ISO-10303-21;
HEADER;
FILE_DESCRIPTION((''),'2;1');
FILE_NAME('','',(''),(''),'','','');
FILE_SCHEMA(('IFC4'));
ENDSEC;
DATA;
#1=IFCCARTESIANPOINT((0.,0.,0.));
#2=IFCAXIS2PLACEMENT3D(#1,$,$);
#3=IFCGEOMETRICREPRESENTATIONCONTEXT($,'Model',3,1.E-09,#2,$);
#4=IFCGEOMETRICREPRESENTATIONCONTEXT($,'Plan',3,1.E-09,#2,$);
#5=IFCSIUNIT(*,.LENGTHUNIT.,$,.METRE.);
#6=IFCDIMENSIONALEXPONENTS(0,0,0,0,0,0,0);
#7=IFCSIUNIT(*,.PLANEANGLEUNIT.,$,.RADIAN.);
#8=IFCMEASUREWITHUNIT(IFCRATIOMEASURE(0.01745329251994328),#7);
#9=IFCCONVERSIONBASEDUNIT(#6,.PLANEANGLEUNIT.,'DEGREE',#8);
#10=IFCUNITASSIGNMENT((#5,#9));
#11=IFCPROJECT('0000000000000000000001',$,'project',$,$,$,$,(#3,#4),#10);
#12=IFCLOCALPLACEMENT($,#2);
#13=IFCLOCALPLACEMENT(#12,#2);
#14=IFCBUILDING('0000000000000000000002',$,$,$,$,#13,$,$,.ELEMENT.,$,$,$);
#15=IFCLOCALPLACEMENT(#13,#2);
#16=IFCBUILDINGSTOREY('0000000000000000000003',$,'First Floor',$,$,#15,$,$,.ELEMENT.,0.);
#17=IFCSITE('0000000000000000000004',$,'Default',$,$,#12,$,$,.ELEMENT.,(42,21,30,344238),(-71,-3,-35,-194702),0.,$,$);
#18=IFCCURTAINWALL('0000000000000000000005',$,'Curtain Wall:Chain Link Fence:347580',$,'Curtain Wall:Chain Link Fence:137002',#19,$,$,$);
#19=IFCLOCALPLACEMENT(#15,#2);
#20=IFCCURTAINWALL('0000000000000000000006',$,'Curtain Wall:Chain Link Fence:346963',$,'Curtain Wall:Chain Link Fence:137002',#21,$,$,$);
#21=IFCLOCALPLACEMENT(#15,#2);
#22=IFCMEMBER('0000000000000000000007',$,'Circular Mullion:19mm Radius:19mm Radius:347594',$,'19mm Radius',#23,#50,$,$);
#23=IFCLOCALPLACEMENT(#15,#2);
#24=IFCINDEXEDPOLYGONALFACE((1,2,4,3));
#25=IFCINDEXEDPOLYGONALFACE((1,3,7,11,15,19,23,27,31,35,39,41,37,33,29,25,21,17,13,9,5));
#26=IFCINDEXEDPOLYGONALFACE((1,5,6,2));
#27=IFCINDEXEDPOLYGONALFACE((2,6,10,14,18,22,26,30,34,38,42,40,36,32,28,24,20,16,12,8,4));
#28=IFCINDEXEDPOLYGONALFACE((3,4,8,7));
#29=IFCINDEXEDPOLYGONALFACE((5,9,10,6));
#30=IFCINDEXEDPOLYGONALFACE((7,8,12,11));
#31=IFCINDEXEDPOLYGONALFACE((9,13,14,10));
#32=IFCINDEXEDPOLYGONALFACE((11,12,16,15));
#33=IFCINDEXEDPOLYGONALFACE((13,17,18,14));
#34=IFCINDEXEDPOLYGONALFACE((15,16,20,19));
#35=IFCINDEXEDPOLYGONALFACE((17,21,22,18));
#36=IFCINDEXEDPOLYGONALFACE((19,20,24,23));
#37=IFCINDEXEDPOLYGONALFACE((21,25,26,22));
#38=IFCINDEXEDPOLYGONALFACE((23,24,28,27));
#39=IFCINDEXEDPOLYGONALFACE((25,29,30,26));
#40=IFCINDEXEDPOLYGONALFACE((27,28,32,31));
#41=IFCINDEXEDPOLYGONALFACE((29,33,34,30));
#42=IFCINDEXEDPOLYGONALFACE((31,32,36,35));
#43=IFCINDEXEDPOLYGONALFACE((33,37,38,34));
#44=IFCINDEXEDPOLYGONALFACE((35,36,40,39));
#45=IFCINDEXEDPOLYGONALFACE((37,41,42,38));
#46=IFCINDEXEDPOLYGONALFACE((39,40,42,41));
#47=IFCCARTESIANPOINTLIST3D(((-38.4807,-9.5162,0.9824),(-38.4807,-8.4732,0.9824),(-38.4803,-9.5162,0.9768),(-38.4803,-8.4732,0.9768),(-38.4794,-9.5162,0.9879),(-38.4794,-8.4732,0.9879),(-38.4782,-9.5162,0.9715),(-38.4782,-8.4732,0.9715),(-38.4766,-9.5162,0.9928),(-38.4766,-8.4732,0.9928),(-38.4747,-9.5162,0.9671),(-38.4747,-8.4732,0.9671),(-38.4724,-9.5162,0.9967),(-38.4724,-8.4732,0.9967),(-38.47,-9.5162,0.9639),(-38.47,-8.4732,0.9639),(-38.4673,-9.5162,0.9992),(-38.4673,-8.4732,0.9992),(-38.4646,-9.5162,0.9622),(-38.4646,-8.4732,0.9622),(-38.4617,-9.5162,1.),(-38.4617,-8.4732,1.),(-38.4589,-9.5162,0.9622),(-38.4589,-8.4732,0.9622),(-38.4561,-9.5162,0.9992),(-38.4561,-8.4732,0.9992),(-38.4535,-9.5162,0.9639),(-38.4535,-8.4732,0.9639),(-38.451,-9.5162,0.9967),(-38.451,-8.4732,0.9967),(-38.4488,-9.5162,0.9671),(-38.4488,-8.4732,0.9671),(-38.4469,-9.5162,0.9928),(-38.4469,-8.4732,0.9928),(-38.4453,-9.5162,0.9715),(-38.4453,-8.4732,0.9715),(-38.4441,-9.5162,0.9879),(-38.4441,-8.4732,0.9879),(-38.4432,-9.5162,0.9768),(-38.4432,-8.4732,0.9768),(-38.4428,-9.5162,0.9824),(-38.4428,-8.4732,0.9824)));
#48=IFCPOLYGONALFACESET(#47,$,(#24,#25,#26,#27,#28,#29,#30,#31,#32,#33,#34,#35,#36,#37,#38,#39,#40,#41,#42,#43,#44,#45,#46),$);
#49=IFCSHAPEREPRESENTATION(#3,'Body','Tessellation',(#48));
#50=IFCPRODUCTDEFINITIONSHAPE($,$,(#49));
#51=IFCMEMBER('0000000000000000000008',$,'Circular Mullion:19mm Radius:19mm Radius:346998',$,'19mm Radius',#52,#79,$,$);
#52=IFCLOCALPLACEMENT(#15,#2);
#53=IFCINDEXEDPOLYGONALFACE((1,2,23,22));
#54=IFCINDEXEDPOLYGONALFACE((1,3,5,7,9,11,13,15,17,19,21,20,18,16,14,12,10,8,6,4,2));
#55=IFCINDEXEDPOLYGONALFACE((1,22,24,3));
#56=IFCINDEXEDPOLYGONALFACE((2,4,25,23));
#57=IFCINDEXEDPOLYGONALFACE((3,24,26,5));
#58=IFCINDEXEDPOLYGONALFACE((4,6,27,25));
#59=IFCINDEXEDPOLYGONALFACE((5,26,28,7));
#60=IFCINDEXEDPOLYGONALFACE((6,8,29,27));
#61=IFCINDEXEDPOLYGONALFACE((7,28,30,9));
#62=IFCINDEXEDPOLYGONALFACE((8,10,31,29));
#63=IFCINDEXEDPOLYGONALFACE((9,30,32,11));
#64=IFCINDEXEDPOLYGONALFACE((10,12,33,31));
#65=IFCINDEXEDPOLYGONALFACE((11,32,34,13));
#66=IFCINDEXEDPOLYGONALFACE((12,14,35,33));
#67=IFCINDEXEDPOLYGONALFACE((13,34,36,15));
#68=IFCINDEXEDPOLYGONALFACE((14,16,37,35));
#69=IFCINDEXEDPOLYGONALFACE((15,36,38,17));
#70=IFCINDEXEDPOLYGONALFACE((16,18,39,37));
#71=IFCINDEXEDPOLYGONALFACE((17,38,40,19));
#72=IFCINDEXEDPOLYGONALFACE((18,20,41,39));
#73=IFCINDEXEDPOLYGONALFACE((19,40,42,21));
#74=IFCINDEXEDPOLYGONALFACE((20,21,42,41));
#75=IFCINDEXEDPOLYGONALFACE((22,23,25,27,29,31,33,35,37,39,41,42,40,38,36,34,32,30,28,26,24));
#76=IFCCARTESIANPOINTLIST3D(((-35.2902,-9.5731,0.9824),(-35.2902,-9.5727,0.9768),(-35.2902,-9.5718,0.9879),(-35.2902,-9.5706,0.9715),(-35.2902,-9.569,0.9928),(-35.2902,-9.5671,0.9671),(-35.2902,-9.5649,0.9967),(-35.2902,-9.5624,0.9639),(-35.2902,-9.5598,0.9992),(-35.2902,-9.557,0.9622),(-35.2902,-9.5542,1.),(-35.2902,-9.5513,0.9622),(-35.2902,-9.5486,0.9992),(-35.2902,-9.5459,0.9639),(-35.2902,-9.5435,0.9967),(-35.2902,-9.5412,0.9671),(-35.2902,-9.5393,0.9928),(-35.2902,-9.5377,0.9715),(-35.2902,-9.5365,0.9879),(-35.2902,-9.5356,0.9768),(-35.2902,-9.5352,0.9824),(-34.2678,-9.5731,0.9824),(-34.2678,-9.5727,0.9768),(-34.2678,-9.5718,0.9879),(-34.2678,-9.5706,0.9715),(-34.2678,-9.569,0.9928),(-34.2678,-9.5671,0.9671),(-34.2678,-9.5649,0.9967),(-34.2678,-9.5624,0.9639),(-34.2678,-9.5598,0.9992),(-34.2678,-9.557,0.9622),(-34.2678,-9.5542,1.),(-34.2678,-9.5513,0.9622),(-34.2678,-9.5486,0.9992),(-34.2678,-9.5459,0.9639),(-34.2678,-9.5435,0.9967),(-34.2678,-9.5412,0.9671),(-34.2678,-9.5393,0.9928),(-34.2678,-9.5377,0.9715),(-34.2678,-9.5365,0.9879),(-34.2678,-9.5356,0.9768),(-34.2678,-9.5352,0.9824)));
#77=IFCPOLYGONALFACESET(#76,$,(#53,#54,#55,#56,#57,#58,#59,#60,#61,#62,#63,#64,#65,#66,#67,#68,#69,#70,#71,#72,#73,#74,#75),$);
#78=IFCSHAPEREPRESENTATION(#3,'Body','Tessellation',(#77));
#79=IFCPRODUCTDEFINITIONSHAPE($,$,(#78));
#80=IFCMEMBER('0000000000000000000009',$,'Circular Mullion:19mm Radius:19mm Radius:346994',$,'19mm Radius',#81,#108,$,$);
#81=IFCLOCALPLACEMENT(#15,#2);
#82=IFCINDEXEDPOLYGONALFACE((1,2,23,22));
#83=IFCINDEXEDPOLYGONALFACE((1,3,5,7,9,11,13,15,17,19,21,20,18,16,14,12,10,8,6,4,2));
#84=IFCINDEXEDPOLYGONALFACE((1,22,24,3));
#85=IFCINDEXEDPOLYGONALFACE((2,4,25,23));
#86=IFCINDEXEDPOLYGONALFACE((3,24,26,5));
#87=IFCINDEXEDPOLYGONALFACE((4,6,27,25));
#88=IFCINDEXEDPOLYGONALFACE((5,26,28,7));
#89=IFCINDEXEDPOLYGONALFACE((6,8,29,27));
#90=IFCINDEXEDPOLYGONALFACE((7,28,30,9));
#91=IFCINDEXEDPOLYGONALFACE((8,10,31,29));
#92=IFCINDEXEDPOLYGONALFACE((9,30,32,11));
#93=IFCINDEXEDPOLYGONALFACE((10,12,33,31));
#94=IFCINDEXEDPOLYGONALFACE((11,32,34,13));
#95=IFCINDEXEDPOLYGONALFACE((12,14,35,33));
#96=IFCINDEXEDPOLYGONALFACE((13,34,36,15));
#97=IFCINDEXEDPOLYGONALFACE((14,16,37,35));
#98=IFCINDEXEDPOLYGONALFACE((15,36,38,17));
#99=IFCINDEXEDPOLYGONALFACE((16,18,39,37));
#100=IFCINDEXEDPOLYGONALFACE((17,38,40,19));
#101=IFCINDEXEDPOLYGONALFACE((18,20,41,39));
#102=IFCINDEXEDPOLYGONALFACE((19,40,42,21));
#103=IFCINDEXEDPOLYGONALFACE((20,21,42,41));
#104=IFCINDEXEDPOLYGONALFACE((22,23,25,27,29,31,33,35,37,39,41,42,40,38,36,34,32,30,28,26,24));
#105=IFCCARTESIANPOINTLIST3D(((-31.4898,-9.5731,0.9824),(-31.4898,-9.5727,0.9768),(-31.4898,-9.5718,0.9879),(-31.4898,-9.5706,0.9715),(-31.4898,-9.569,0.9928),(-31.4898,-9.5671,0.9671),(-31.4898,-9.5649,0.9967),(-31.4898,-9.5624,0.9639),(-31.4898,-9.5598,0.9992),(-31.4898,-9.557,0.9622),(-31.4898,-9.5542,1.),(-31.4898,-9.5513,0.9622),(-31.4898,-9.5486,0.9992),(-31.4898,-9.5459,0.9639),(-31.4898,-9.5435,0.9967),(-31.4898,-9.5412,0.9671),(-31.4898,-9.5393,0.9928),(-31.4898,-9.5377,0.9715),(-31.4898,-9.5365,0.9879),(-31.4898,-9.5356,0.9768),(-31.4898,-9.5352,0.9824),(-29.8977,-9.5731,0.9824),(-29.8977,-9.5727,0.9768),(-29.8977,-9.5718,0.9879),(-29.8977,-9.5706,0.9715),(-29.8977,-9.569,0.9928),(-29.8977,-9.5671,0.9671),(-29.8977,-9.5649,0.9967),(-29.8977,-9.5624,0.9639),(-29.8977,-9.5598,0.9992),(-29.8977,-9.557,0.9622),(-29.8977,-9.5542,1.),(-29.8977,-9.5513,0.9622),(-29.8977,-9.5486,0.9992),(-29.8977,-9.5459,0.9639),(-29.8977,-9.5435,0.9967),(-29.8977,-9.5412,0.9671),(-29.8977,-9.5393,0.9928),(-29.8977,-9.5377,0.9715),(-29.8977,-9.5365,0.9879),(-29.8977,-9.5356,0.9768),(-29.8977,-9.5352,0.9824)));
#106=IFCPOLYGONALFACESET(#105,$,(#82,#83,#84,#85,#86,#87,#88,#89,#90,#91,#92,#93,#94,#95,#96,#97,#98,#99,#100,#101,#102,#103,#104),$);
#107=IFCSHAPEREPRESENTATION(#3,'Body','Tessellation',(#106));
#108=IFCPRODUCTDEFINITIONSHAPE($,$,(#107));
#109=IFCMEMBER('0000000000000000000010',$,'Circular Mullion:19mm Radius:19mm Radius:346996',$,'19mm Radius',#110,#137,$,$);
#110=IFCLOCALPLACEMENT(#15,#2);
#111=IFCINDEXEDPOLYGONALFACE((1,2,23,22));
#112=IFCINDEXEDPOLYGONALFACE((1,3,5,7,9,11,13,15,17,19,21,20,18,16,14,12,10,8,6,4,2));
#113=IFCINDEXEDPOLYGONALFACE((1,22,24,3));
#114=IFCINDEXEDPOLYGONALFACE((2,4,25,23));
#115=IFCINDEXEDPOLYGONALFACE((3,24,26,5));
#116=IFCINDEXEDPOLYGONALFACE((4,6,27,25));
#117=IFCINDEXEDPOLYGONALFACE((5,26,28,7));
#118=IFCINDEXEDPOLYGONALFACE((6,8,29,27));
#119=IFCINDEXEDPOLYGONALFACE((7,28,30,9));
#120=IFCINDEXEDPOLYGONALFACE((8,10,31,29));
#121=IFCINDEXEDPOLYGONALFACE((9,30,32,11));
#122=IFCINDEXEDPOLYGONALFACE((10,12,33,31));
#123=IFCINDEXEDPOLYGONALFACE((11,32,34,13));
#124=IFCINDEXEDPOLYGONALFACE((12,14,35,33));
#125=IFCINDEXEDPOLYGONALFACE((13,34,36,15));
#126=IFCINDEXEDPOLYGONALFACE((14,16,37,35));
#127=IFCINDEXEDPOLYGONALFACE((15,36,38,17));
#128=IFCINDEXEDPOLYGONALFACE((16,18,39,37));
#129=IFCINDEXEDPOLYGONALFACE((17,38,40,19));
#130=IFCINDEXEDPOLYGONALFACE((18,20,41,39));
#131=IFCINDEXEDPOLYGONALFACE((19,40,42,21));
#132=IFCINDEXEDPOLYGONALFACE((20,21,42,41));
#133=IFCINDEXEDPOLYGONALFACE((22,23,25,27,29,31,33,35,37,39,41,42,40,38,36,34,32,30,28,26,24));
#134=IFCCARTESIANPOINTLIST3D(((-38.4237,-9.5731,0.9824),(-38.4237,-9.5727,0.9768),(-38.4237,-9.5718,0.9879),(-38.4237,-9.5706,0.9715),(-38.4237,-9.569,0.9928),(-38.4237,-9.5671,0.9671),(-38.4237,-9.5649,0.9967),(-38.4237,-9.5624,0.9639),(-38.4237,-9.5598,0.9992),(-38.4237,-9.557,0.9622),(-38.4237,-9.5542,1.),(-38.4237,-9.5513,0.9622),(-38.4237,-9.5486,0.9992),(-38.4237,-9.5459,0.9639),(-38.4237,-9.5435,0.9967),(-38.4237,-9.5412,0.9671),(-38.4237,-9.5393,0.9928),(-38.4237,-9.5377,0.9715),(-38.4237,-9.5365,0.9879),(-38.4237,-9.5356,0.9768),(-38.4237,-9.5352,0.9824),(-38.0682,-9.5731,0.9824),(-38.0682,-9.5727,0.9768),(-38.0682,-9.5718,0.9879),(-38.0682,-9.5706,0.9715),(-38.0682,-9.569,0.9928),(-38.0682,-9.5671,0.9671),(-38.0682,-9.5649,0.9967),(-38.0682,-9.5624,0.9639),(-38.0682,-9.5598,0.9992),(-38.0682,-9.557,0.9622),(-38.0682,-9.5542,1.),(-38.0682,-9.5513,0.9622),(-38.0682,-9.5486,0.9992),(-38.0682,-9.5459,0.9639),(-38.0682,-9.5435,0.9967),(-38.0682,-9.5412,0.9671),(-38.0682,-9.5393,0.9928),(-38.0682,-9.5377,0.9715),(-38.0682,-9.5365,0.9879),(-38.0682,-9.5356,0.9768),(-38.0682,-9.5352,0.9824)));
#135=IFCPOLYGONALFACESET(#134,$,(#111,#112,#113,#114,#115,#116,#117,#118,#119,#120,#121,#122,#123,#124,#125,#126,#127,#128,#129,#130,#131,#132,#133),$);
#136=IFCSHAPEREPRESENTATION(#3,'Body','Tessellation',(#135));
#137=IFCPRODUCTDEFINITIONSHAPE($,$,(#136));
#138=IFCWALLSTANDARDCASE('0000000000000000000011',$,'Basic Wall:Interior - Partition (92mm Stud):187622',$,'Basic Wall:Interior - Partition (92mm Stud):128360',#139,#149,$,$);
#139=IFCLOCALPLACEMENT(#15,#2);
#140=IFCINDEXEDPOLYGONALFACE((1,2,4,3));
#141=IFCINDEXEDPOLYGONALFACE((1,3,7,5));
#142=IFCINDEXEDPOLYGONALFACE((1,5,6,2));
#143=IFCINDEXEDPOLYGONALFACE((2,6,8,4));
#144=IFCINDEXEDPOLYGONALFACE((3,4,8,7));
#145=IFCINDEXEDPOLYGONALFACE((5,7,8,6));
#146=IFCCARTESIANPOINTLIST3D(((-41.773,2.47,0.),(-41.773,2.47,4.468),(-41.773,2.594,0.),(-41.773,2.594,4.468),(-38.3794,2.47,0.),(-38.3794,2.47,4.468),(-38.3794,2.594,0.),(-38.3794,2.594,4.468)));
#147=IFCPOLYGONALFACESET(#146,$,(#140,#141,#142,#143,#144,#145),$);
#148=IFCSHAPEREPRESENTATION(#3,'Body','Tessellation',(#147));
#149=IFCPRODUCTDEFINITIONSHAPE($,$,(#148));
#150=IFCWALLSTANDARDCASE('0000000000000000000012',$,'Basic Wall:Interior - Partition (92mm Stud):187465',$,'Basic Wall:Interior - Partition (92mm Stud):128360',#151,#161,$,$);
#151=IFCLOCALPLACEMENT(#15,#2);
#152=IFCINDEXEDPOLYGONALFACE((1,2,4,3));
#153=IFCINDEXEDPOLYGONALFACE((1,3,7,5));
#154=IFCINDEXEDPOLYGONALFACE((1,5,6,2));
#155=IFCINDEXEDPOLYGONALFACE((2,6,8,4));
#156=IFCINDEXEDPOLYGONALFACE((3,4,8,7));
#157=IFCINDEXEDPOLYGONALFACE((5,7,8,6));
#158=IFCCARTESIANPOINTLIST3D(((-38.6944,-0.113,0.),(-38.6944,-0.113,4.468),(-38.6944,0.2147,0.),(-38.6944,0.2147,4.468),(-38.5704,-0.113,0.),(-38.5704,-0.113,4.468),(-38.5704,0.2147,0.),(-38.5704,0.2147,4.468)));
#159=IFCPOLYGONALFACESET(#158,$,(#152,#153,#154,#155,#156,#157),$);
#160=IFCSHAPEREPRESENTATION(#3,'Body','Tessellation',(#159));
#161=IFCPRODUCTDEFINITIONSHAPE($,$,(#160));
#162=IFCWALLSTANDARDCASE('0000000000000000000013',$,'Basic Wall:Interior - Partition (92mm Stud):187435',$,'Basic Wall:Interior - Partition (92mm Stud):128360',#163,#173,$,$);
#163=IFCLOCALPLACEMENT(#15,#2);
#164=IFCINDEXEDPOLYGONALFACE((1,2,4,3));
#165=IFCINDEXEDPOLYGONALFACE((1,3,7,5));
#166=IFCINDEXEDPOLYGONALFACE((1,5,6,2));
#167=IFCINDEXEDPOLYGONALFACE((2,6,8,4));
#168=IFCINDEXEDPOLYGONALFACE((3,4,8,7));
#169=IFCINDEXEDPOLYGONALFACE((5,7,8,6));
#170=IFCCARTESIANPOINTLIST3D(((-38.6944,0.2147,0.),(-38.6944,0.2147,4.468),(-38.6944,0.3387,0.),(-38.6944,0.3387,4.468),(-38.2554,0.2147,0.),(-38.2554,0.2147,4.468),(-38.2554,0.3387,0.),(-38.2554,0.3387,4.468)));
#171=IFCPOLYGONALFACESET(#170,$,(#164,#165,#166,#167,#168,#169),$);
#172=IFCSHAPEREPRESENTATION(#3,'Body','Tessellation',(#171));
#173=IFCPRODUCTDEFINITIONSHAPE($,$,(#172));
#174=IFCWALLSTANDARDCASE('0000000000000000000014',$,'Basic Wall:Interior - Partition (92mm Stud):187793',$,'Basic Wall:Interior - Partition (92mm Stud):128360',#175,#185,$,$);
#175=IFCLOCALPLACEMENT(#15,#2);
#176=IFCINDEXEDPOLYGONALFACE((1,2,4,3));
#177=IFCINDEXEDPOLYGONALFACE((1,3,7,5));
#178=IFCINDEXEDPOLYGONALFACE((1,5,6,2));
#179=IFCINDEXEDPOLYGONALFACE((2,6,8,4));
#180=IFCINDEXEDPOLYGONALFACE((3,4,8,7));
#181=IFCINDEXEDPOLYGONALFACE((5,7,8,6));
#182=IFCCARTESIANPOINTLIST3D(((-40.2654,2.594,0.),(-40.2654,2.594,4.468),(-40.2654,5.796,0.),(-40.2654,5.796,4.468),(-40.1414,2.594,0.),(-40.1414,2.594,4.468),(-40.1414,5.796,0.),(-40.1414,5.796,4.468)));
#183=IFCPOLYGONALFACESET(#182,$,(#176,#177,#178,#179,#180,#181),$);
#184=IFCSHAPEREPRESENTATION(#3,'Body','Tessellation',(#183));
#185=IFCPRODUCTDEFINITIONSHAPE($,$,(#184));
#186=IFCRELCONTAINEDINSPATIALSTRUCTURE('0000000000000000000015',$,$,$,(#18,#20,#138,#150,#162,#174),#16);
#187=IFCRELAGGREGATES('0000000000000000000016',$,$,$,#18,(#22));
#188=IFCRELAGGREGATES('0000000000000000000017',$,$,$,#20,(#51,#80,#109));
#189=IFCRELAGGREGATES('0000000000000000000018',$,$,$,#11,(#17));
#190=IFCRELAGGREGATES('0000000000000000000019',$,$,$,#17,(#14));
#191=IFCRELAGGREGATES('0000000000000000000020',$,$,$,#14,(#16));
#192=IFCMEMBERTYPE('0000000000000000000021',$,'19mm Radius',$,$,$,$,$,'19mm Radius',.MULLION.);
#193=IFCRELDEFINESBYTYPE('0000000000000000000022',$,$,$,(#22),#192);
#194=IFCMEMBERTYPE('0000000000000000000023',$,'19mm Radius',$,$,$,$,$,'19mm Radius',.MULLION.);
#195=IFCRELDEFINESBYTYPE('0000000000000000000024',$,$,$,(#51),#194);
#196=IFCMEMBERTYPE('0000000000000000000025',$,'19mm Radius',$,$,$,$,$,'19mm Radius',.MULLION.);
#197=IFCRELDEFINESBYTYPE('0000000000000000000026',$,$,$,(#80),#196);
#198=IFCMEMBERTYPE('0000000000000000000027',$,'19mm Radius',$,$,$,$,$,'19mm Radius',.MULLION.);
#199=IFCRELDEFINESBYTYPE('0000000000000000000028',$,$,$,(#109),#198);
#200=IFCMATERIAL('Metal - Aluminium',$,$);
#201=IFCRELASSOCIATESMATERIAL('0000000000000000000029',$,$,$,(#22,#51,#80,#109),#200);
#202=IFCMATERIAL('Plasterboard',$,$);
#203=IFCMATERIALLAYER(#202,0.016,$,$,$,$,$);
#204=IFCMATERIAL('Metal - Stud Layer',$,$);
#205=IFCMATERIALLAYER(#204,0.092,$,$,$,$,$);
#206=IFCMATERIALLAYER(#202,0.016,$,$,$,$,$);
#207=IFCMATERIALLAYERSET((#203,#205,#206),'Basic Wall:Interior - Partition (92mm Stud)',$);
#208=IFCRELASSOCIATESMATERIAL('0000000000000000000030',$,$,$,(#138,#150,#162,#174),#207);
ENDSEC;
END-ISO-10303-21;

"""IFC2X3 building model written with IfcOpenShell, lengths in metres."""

from ifc_helpers import new_model, entity, si_unit, converted_unit, frame, frame_2d, origin, origin_2d_with_axis, place, context, project, spatial, rectangle, circle, extrude, source, transform, mapped, material, layer, layer_set, layer_usage, type_object, type_shapes, element, aggregate, save


model = new_model("IFC2X3")

# Units and contexts
model_context = context("Model", 3, precision=1e-09, world=origin())
plan_context = context("Plan", 3, precision=1e-09, world=origin())
ifc_project = project(units=[si_unit("LENGTHUNIT", "METRE"), converted_unit("PLANEANGLEUNIT", "DEGREE", entity("IfcRatioMeasure", 0.01745329251994328), si_unit("PLANEANGLEUNIT", "RADIAN"), dimensions=[0, 0, 0, 0, 0, 0, 0])], contexts=[model_context, plan_context])

# Site, building, storey
site_placement = place(None, origin())
site = spatial("IfcSite", under=ifc_project, at=site_placement, Name="Default", CompositionType="ELEMENT", RefLatitude=(42, 21, 30, 344238), RefLongitude=(-71, -3, -35, -194702), RefElevation=0.0)
building_placement = place(site_placement, origin())
building = spatial("IfcBuilding", under=site, at=building_placement, CompositionType="ELEMENT")
storey_placement = place(building_placement, origin())
storey = spatial("IfcBuildingStorey", under=building, at=storey_placement, Name="First Floor", CompositionType="ELEMENT", Elevation=0.0)

# Curtain walls
curtain_wall_1_placement = place(storey_placement, origin())
curtain_wall_1 = element("IfcCurtainWall", 1, at=curtain_wall_1_placement, inside=storey, Name="Curtain Wall:Chain Link Fence:347580", ObjectType="Curtain Wall:Chain Link Fence:137002")
ifc_material_1 = material(Name="Metal - Aluminium")
curtain_wall_2_placement = place(storey_placement, origin())
curtain_wall_2 = element("IfcCurtainWall", 2, at=curtain_wall_2_placement, inside=storey, Name="Curtain Wall:Chain Link Fence:346963", ObjectType="Curtain Wall:Chain Link Fence:137002")

# Members
member_type_1 = type_object("IfcMemberType", Name="19mm Radius", ElementType="19mm Radius", PredefinedType="MULLION")
shared_shape_1 = source(origin(), model_context, "Body", "SweptSolid", [
    extrude(circle(Radius=0.019, at=origin_2d_with_axis()), frame((-0.019, 0.0, -1.043)), (0.0, 0.0, 1.0), 1.043),
])
type_shapes(member_type_1, [shared_shape_1])
member_1_placement = place(storey_placement, frame((-38.4617, -8.4732, 1.0), z_axis=(0.0, 1.0, 0.0), x_axis=(0.0, 0.0, 1.0)))
member_1 = element("IfcMember", 3, at=member_1_placement, type_object=member_type_1, material=ifc_material_1, Name="Circular Mullion:19mm Radius:19mm Radius:347594", ObjectType="19mm Radius", context=model_context, shape_type="MappedRepresentation", body=[
    mapped(shared_shape_1, transform((0.0, 0.0, 0.0), scale=1.0)),
])
member_type_2 = type_object("IfcMemberType", Name="19mm Radius", ElementType="19mm Radius", PredefinedType="MULLION")
shared_shape_2 = source(origin(), model_context, "Body", "SweptSolid", [
    extrude(circle(Radius=0.019, at=origin_2d_with_axis()), frame((-0.019, 0.0, -1.0224)), (0.0, 0.0, 1.0), 1.0224),
])
type_shapes(member_type_2, [shared_shape_2])
member_2_placement = place(storey_placement, frame((-34.2678, -9.5542, 1.0), z_axis=(1.0, 0.0, 0.0), x_axis=(0.0, 0.0, 1.0)))
member_2 = element("IfcMember", 4, at=member_2_placement, type_object=member_type_2, material=ifc_material_1, Name="Circular Mullion:19mm Radius:19mm Radius:346998", ObjectType="19mm Radius", context=model_context, shape_type="MappedRepresentation", body=[
    mapped(shared_shape_2, transform((0.0, 0.0, 0.0), scale=1.0)),
])
member_type_3 = type_object("IfcMemberType", Name="19mm Radius", ElementType="19mm Radius", PredefinedType="MULLION")
shared_shape_3 = source(origin(), model_context, "Body", "SweptSolid", [
    extrude(circle(Radius=0.019, at=origin_2d_with_axis()), frame((-0.019, 0.0, -1.5921)), (0.0, 0.0, 1.0), 1.5921),
])
type_shapes(member_type_3, [shared_shape_3])
member_3_placement = place(storey_placement, frame((-29.8977, -9.5542, 1.0), z_axis=(1.0, 0.0, 0.0), x_axis=(0.0, 0.0, 1.0)))
member_3 = element("IfcMember", 5, at=member_3_placement, type_object=member_type_3, material=ifc_material_1, Name="Circular Mullion:19mm Radius:19mm Radius:346994", ObjectType="19mm Radius", context=model_context, shape_type="MappedRepresentation", body=[
    mapped(shared_shape_3, transform((0.0, 0.0, 0.0), scale=1.0)),
])
member_type_4 = type_object("IfcMemberType", Name="19mm Radius", ElementType="19mm Radius", PredefinedType="MULLION")
shared_shape_4 = source(origin(), model_context, "Body", "SweptSolid", [
    extrude(circle(Radius=0.019, at=origin_2d_with_axis()), frame((-0.019, 0.0, -0.3556)), (0.0, 0.0, 1.0), 0.3556),
])
type_shapes(member_type_4, [shared_shape_4])
member_4_placement = place(storey_placement, frame((-38.0682, -9.5542, 1.0), z_axis=(1.0, 0.0, 0.0), x_axis=(0.0, 0.0, 1.0)))
member_4 = element("IfcMember", 6, at=member_4_placement, type_object=member_type_4, material=ifc_material_1, Name="Circular Mullion:19mm Radius:19mm Radius:346996", ObjectType="19mm Radius", context=model_context, shape_type="MappedRepresentation", body=[
    mapped(shared_shape_4, transform((0.0, 0.0, 0.0), scale=1.0)),
])

aggregate(curtain_wall_1, [member_1])
aggregate(curtain_wall_2, [member_2, member_3, member_4])

# Walls
ifc_material_2 = material(Name="Plasterboard")
ifc_layer_1 = layer(ifc_material_2, 0.016)
ifc_material_3 = material(Name="Metal - Stud Layer")
ifc_layer_2 = layer(ifc_material_3, 0.092)
ifc_layer_3 = layer(ifc_material_2, 0.016)
ifc_layer_set_1 = layer_set([ifc_layer_1, ifc_layer_2, ifc_layer_3], Name="Basic Wall:Interior - Partition (92mm Stud)")
ifc_layer_usage_1 = layer_usage(ifc_layer_set_1, "AXIS2", "NEGATIVE", 0.062)
wall_1_placement = place(storey_placement, frame((-38.3794, 2.532, 0.0), z_axis=(0.0, 0.0, 1.0), x_axis=(-1.0, 0.0, 0.0)))
element("IfcWallStandardCase", 7, at=wall_1_placement, inside=storey, material=ifc_layer_usage_1, Name="Basic Wall:Interior - Partition (92mm Stud):187622", ObjectType="Basic Wall:Interior - Partition (92mm Stud):128360", context=model_context, shape_type="SweptSolid", body=[
    extrude(rectangle(XDim=3.3936, YDim=0.124, at=frame_2d((1.6968, 0.0), x_axis=(-1.0, 0.0))), origin(), (0.0, 0.0, 1.0), 4.468),
])
wall_2_placement = place(storey_placement, frame((-38.6324, 0.2147, 0.0), z_axis=(0.0, 0.0, 1.0), x_axis=(0.0, -1.0, 0.0)))
element("IfcWallStandardCase", 8, at=wall_2_placement, inside=storey, material=ifc_layer_usage_1, Name="Basic Wall:Interior - Partition (92mm Stud):187465", ObjectType="Basic Wall:Interior - Partition (92mm Stud):128360", context=model_context, shape_type="SweptSolid", body=[
    extrude(rectangle(XDim=0.3277, YDim=0.124, at=frame_2d((0.1639, 0.0), x_axis=(-1.0, 0.0))), origin(), (0.0, 0.0, 1.0), 4.468),
])
wall_3_placement = place(storey_placement, frame((-38.2554, 0.2767, 0.0), z_axis=(0.0, 0.0, 1.0), x_axis=(-1.0, 0.0, 0.0)))
element("IfcWallStandardCase", 9, at=wall_3_placement, inside=storey, material=ifc_layer_usage_1, Name="Basic Wall:Interior - Partition (92mm Stud):187435", ObjectType="Basic Wall:Interior - Partition (92mm Stud):128360", context=model_context, shape_type="SweptSolid", body=[
    extrude(rectangle(XDim=0.439, YDim=0.124, at=frame_2d((0.2195, 0.0), x_axis=(-1.0, 0.0))), origin(), (0.0, 0.0, 1.0), 4.468),
])
wall_4_placement = place(storey_placement, frame((-40.2034, 2.594, 0.0), z_axis=(0.0, 0.0, 1.0), x_axis=(0.0, 1.0, 0.0)))
element("IfcWallStandardCase", 10, at=wall_4_placement, inside=storey, material=ifc_layer_usage_1, Name="Basic Wall:Interior - Partition (92mm Stud):187793", ObjectType="Basic Wall:Interior - Partition (92mm Stud):128360", context=model_context, shape_type="SweptSolid", body=[
    extrude(rectangle(XDim=3.202, YDim=0.124, at=frame_2d((1.601, 0.0), x_axis=(-1.0, 0.0))), origin(), (0.0, 0.0, 1.0), 4.468),
])

save(model, "model.ifc")
